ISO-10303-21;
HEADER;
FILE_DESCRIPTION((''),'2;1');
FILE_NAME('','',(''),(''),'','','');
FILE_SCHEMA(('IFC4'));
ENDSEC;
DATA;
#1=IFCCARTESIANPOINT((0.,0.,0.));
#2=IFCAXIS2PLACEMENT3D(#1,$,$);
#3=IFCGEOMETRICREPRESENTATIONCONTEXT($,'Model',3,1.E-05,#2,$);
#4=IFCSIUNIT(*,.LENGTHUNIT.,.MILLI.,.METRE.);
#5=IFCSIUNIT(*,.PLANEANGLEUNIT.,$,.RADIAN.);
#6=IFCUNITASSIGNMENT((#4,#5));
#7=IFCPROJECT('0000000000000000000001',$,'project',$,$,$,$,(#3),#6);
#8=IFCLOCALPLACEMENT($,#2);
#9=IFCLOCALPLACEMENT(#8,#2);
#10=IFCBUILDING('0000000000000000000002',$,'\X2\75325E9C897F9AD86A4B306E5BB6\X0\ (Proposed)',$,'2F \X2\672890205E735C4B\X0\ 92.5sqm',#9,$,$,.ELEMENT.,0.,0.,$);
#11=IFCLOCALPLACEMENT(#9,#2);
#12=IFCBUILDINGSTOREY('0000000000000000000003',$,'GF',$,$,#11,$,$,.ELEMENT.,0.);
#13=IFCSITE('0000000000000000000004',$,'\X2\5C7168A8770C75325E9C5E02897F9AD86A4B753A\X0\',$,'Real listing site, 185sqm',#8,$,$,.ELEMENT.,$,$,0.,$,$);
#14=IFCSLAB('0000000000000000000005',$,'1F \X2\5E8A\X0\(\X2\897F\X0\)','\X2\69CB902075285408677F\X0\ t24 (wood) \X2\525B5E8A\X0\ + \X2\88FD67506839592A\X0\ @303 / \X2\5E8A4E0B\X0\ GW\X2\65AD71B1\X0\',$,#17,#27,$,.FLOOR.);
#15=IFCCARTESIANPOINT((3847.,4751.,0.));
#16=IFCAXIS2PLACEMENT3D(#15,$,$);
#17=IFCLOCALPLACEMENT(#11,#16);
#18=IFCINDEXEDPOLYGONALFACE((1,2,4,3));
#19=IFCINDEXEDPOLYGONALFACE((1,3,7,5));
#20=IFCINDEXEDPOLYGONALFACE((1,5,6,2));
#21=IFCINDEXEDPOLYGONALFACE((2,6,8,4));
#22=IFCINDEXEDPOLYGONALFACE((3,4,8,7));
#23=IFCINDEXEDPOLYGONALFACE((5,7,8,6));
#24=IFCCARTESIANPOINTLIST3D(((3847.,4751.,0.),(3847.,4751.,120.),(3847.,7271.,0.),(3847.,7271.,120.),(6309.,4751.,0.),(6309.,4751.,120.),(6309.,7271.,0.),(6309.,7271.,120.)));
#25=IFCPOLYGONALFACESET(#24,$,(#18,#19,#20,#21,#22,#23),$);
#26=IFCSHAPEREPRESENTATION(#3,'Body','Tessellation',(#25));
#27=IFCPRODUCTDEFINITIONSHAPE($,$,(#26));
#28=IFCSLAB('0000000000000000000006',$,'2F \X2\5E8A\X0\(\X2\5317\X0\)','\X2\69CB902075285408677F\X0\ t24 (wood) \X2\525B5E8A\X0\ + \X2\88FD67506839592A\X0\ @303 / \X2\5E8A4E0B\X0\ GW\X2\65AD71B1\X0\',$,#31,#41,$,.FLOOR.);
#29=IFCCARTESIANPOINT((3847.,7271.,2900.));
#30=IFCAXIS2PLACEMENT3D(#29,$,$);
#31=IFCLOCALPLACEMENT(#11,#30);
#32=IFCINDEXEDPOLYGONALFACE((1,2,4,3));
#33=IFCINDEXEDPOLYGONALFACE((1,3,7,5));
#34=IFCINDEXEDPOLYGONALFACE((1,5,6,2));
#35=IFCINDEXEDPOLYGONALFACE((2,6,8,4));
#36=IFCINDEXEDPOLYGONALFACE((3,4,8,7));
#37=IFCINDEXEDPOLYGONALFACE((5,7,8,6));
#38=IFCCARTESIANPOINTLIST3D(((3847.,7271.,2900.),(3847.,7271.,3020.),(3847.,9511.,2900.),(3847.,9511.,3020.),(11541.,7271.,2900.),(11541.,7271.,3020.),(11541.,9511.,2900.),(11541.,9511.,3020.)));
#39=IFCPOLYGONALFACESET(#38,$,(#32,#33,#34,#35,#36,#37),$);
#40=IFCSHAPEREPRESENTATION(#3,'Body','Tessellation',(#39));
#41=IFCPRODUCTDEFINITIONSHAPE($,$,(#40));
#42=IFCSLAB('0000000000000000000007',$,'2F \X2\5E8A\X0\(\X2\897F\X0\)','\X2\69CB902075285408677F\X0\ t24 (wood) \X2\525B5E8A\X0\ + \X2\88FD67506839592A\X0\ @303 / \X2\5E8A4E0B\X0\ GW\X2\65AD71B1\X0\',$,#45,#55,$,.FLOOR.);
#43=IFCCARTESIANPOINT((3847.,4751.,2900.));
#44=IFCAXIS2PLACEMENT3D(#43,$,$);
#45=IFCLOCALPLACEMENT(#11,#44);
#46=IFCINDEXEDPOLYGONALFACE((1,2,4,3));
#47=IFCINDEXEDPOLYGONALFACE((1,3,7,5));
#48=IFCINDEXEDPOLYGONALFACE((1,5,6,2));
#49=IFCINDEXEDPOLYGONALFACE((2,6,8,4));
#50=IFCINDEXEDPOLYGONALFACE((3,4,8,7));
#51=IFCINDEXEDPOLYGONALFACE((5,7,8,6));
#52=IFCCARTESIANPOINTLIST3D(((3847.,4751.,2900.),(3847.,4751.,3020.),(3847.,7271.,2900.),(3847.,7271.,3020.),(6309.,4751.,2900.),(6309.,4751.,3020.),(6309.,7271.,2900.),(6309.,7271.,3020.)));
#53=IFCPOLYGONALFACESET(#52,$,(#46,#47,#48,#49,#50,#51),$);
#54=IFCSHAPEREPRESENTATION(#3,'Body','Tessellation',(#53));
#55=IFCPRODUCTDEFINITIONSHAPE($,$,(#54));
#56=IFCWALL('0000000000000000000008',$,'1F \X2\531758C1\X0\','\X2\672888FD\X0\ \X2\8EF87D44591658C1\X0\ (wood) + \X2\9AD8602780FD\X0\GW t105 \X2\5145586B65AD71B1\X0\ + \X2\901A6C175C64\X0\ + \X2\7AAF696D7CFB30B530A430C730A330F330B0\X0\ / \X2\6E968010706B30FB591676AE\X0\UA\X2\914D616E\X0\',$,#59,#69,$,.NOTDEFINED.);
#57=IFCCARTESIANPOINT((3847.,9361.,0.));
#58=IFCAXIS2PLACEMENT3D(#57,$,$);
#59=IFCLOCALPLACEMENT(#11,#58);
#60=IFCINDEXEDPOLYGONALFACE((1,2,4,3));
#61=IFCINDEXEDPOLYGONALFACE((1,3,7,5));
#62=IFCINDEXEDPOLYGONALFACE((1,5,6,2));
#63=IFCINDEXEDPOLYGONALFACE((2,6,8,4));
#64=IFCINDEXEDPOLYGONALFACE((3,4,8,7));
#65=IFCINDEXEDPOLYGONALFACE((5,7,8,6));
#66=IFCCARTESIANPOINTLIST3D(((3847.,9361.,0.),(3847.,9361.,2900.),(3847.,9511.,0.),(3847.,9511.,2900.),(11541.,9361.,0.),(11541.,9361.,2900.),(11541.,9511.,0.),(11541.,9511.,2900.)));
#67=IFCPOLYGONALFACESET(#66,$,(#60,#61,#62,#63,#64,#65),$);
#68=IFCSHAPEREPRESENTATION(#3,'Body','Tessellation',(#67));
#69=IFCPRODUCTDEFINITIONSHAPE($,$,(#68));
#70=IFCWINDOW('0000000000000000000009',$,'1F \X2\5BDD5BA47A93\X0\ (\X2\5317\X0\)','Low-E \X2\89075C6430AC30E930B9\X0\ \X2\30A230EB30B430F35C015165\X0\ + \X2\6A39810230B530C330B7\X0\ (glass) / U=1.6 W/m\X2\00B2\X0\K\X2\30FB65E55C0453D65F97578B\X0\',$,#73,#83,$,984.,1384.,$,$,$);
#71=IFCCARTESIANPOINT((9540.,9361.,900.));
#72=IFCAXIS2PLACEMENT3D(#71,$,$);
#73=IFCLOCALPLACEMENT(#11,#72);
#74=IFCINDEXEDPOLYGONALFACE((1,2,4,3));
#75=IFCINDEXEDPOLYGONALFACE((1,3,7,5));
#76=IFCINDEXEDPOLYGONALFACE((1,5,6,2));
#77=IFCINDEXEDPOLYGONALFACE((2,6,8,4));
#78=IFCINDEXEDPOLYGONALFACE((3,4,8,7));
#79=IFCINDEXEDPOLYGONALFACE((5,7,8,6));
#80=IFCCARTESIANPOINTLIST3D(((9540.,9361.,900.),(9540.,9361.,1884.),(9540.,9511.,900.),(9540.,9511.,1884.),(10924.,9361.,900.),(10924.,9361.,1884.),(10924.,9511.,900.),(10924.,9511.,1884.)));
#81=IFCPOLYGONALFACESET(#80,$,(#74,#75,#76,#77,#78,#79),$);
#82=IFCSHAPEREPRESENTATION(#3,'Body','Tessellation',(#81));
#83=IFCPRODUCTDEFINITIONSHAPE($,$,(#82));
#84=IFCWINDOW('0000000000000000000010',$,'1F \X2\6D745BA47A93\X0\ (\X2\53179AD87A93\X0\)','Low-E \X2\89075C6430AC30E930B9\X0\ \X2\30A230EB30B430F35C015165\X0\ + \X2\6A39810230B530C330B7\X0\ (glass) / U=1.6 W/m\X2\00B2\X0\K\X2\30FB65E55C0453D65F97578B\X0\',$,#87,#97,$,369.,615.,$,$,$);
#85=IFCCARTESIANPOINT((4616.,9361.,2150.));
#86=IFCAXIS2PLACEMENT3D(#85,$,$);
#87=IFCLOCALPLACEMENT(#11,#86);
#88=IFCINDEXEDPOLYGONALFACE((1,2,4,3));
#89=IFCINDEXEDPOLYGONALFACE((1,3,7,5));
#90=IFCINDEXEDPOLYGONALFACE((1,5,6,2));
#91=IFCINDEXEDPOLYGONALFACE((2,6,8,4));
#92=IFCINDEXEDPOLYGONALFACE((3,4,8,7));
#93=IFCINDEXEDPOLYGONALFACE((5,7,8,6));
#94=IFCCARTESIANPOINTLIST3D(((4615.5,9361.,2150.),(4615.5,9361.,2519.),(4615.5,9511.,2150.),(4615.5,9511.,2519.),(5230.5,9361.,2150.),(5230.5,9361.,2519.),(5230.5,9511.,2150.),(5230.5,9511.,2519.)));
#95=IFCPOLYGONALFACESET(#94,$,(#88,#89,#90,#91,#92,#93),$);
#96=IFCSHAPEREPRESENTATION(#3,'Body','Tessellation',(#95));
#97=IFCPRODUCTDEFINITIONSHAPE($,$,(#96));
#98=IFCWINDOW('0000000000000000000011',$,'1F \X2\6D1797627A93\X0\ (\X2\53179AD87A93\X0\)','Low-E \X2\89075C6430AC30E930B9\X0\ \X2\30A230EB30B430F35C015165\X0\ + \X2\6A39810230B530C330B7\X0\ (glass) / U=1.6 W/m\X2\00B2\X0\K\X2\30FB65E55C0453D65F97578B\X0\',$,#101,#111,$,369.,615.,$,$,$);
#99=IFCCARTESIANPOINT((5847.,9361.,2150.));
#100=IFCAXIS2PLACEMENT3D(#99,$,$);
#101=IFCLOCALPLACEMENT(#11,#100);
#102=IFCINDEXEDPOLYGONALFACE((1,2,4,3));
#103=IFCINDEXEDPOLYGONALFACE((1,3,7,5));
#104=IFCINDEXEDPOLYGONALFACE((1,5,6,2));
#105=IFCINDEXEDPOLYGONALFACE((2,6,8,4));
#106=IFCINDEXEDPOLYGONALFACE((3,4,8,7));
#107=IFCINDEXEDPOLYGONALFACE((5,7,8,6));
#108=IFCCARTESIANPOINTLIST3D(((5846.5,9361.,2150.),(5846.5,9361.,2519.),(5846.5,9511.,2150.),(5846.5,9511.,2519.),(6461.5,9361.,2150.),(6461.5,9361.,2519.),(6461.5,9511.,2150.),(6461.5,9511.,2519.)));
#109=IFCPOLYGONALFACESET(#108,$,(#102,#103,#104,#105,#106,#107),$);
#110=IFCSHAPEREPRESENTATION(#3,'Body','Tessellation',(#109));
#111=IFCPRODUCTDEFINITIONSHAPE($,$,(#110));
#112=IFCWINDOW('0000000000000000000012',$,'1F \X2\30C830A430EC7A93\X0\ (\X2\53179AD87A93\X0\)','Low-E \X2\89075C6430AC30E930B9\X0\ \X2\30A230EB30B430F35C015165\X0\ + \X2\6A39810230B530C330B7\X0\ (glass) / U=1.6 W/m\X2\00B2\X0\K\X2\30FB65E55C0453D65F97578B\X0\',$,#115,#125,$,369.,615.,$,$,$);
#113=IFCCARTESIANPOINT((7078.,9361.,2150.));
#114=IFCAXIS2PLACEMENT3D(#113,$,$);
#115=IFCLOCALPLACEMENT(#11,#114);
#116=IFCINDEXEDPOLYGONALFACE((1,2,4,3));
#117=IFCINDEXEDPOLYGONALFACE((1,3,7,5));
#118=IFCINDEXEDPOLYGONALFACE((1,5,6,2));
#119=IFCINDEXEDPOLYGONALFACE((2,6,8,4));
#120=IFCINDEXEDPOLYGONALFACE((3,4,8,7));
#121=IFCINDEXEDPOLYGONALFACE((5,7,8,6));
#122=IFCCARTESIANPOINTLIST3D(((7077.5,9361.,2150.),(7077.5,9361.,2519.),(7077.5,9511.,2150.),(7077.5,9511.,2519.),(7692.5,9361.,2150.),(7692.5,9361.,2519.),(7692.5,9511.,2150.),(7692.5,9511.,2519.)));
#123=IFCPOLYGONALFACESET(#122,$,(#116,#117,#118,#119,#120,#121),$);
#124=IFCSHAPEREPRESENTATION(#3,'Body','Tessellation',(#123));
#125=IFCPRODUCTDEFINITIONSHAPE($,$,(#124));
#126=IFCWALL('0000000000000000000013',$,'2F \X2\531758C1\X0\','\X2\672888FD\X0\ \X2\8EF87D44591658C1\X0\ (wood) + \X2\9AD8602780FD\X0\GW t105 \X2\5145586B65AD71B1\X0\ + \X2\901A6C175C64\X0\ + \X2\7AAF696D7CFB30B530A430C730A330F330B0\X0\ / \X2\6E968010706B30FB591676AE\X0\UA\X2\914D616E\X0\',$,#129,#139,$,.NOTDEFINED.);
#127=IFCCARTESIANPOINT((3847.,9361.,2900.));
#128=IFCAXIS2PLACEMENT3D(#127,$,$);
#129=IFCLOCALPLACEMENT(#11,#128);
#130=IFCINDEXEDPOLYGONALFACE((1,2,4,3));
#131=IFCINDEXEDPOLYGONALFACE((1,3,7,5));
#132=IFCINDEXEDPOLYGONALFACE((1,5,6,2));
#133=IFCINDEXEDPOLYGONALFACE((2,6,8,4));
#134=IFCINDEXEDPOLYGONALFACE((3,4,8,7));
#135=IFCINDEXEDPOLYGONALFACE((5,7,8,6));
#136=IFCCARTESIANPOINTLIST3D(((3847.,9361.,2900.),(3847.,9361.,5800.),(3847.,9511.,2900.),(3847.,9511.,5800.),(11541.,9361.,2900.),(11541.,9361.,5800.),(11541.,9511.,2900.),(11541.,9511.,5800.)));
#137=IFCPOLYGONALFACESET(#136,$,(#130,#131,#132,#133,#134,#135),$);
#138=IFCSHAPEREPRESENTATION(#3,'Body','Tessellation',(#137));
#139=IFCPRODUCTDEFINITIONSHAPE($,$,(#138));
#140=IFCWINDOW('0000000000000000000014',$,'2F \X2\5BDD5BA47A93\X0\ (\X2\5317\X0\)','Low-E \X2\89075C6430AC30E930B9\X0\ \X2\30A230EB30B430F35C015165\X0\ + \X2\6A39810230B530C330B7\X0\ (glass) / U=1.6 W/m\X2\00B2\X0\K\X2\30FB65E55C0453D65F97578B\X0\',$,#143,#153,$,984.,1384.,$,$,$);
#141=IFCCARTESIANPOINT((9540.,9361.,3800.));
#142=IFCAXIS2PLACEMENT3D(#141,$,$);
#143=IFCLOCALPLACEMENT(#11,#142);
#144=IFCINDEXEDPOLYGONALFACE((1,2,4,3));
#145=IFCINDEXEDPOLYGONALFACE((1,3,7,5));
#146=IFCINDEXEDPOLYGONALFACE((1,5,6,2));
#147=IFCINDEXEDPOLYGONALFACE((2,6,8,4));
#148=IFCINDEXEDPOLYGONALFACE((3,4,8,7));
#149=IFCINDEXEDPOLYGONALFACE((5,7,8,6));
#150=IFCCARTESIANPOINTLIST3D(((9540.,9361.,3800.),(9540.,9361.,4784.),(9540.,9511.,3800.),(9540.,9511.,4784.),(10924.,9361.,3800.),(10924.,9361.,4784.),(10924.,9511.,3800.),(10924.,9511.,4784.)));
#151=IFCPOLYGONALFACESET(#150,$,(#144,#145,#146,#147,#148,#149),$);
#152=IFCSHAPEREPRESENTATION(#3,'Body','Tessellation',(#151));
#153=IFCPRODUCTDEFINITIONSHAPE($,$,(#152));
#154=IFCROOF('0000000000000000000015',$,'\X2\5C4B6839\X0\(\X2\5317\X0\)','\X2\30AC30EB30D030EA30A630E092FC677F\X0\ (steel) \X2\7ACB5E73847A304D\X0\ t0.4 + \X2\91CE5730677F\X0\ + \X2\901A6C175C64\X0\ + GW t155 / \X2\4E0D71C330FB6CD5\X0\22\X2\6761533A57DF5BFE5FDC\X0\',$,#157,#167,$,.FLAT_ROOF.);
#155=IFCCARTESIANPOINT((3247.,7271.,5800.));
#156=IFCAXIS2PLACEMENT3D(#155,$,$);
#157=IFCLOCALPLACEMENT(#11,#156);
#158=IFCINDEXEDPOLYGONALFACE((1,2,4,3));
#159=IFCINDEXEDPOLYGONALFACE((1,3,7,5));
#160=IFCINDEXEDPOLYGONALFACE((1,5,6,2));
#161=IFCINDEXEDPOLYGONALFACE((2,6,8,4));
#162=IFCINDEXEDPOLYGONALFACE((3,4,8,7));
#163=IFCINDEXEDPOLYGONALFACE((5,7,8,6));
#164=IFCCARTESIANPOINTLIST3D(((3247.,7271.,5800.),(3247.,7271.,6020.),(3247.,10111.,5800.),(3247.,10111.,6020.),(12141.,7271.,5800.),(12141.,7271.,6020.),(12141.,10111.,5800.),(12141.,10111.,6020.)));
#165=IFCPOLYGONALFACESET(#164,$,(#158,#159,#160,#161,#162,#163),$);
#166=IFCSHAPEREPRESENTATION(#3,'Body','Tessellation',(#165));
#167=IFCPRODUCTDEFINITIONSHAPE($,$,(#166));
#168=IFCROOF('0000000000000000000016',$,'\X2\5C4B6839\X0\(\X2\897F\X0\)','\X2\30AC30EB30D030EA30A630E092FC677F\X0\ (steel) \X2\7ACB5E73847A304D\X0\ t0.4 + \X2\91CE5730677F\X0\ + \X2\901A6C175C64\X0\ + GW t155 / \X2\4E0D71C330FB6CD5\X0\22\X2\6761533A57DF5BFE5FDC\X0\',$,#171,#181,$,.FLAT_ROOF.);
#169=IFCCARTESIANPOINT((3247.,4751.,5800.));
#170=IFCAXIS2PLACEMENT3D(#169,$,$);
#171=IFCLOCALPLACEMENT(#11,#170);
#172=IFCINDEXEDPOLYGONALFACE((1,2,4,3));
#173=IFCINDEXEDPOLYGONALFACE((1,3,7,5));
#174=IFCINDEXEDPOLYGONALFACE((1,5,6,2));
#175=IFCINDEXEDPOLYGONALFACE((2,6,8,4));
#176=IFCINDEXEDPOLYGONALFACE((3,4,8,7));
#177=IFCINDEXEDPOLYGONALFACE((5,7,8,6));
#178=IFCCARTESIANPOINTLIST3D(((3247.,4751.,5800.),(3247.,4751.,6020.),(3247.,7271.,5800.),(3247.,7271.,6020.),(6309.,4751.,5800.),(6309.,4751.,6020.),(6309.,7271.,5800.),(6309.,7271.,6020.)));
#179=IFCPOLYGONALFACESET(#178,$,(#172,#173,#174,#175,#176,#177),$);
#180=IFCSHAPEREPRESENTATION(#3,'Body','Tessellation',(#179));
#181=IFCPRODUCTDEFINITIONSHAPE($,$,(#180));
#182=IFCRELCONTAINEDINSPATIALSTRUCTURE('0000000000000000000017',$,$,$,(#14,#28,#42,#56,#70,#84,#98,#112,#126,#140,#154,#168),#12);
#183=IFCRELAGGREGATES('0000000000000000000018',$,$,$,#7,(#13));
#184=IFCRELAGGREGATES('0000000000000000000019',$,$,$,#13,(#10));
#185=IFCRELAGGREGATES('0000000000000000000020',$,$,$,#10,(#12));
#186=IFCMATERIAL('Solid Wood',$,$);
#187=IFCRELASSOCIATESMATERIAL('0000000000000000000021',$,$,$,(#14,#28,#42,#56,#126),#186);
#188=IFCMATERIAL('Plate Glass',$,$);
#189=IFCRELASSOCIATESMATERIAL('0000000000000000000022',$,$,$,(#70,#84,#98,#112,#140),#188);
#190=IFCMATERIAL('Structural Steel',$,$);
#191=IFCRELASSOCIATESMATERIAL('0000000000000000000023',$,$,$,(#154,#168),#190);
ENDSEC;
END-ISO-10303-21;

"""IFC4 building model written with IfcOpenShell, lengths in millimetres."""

from ifc_helpers import new_model, si_unit, frame, frame_2d, origin, place, context, project, spatial, rectangle, extrude, material, element, fill, save


model = new_model("IFC4")

# Units and contexts
model_context = context("Model", 3, precision=1e-05, world=origin())
ifc_project = project(units=[si_unit("LENGTHUNIT", "METRE", prefix="MILLI"), si_unit("PLANEANGLEUNIT", "RADIAN")], contexts=[model_context])

# Site, building, storey
site_placement = place(None, origin())
site = spatial("IfcSite", under=ifc_project, at=site_placement, Name="山梨県甲府市西高橋町", ObjectType="Real listing site, 185sqm", CompositionType="ELEMENT", RefElevation=0.0)
building_placement = place(site_placement, origin())
building = spatial("IfcBuilding", under=site, at=building_placement, Name="甲府西高橋の家 (Proposed)", ObjectType="2F 木造平屋 92.5sqm", CompositionType="ELEMENT", ElevationOfRefHeight=0.0, ElevationOfTerrain=0.0)
storey_placement = place(building_placement, origin())
storey = spatial("IfcBuildingStorey", under=building, at=storey_placement, Name="GF", CompositionType="ELEMENT", Elevation=0.0)

# Slabs
ifc_material_1 = material(Name="Solid Wood")
slab_1_placement = place(storey_placement, frame((3847.0, 4751.0, 0.0)))
element("IfcSlab", 1, at=slab_1_placement, inside=storey, material=ifc_material_1, Name="1F 床(西)", Description="構造用合板 t24 (wood) 剛床 + 製材根太 @303 / 床下 GW断熱", PredefinedType="FLOOR", context=model_context, shape_type="SweptSolid", body=[
    extrude(rectangle(XDim=2462.0, YDim=2520.0, at=frame_2d((1231.0, 1260.0))), frame((3847.0, 4751.0, 0.0)), (0.0, 0.0, 1.0), 120.0),
])
slab_2_placement = place(storey_placement, frame((3847.0, 7271.0, 2900.0)))
element("IfcSlab", 2, at=slab_2_placement, inside=storey, material=ifc_material_1, Name="2F 床(北)", Description="構造用合板 t24 (wood) 剛床 + 製材根太 @303 / 床下 GW断熱", PredefinedType="FLOOR", context=model_context, shape_type="SweptSolid", body=[
    extrude(rectangle(XDim=7694.0, YDim=2240.0, at=frame_2d((3847.0, 1120.0))), frame((3847.0, 7271.0, 2900.0)), (0.0, 0.0, 1.0), 120.0),
])
slab_3_placement = place(storey_placement, frame((3847.0, 4751.0, 2900.0)))
element("IfcSlab", 3, at=slab_3_placement, inside=storey, material=ifc_material_1, Name="2F 床(西)", Description="構造用合板 t24 (wood) 剛床 + 製材根太 @303 / 床下 GW断熱", PredefinedType="FLOOR", context=model_context, shape_type="SweptSolid", body=[
    extrude(rectangle(XDim=2462.0, YDim=2520.0, at=frame_2d((1231.0, 1260.0))), frame((3847.0, 4751.0, 2900.0)), (0.0, 0.0, 1.0), 120.0),
])

# Wall, openings, windows
wall_1_placement = place(storey_placement, frame((3847.0, 9361.0, 0.0)))
wall_1 = element("IfcWall", 4, at=wall_1_placement, inside=storey, material=ifc_material_1, Name="1F 北壁", Description="木製 軸組外壁 (wood) + 高性能GW t105 充填断熱 + 通気層 + 窯業系サイディング / 準耐火・外皮UA配慮", PredefinedType="NOTDEFINED", context=model_context, shape_type="SweptSolid", body=[
    extrude(rectangle(XDim=7694.0, YDim=150.0, at=frame_2d((3847.0, 75.0))), frame((3847.0, 9361.0, 0.0)), (0.0, 0.0, 1.0), 2900.0),
])
opening_1_placement = place(storey_placement, frame((9540.0, 9361.0, 900.0)))
opening_1 = element("IfcOpeningElement", 5, at=opening_1_placement, cuts=wall_1, PredefinedType="NOTDEFINED", context=model_context, shape_type="SweptSolid", body=[
    extrude(rectangle(XDim=1384.0, YDim=150.0, at=frame_2d((692.0, 75.0))), frame((9540.0, 9361.0, 900.0)), (0.0, 0.0, 1.0), 984.0),
])
opening_2_placement = place(storey_placement, frame((4616.0, 9361.0, 2150.0)))
opening_2 = element("IfcOpeningElement", 6, at=opening_2_placement, cuts=wall_1, PredefinedType="NOTDEFINED", context=model_context, shape_type="SweptSolid", body=[
    extrude(rectangle(XDim=615.0, YDim=150.0, at=frame_2d((307.0, 75.0))), frame((4616.0, 9361.0, 2150.0)), (0.0, 0.0, 1.0), 369.0),
])
opening_3_placement = place(storey_placement, frame((5847.0, 9361.0, 2150.0)))
opening_3 = element("IfcOpeningElement", 7, at=opening_3_placement, cuts=wall_1, PredefinedType="NOTDEFINED", context=model_context, shape_type="SweptSolid", body=[
    extrude(rectangle(XDim=615.0, YDim=150.0, at=frame_2d((307.0, 75.0))), frame((5847.0, 9361.0, 2150.0)), (0.0, 0.0, 1.0), 369.0),
])
opening_4_placement = place(storey_placement, frame((7078.0, 9361.0, 2150.0)))
opening_4 = element("IfcOpeningElement", 8, at=opening_4_placement, cuts=wall_1, PredefinedType="NOTDEFINED", context=model_context, shape_type="SweptSolid", body=[
    extrude(rectangle(XDim=615.0, YDim=150.0, at=frame_2d((307.0, 75.0))), frame((7078.0, 9361.0, 2150.0)), (0.0, 0.0, 1.0), 369.0),
])
ifc_material_2 = material(Name="Plate Glass")
window_1_placement = place(storey_placement, frame((9540.0, 9361.0, 900.0)))
window_1 = element("IfcWindow", 9, at=window_1_placement, inside=storey, material=ifc_material_2, Name="1F 寝室窓 (北)", Description="Low-E 複層ガラス アルゴン封入 + 樹脂サッシ (glass) / U=1.6 W/m²K・日射取得型", OverallHeight=984.0, OverallWidth=1384.0, context=model_context, shape_type="SweptSolid", body=[
    extrude(rectangle(XDim=1384.0, YDim=150.0, at=frame_2d((692.0, 75.0))), frame((9540.0, 9361.0, 900.0)), (0.0, 0.0, 1.0), 984.0),
])
fill(opening_1, window_1)
window_2_placement = place(storey_placement, frame((4616.0, 9361.0, 2150.0)))
window_2 = element("IfcWindow", 10, at=window_2_placement, inside=storey, material=ifc_material_2, Name="1F 浴室窓 (北高窓)", Description="Low-E 複層ガラス アルゴン封入 + 樹脂サッシ (glass) / U=1.6 W/m²K・日射取得型", OverallHeight=369.0, OverallWidth=615.0, context=model_context, shape_type="SweptSolid", body=[
    extrude(rectangle(XDim=615.0, YDim=150.0, at=frame_2d((307.0, 75.0))), frame((4616.0, 9361.0, 2150.0)), (0.0, 0.0, 1.0), 369.0),
])
fill(opening_2, window_2)
window_3_placement = place(storey_placement, frame((5847.0, 9361.0, 2150.0)))
window_3 = element("IfcWindow", 11, at=window_3_placement, inside=storey, material=ifc_material_2, Name="1F 洗面窓 (北高窓)", Description="Low-E 複層ガラス アルゴン封入 + 樹脂サッシ (glass) / U=1.6 W/m²K・日射取得型", OverallHeight=369.0, OverallWidth=615.0, context=model_context, shape_type="SweptSolid", body=[
    extrude(rectangle(XDim=615.0, YDim=150.0, at=frame_2d((307.0, 75.0))), frame((5847.0, 9361.0, 2150.0)), (0.0, 0.0, 1.0), 369.0),
])
fill(opening_3, window_3)
window_4_placement = place(storey_placement, frame((7078.0, 9361.0, 2150.0)))
window_4 = element("IfcWindow", 12, at=window_4_placement, inside=storey, material=ifc_material_2, Name="1F トイレ窓 (北高窓)", Description="Low-E 複層ガラス アルゴン封入 + 樹脂サッシ (glass) / U=1.6 W/m²K・日射取得型", OverallHeight=369.0, OverallWidth=615.0, context=model_context, shape_type="SweptSolid", body=[
    extrude(rectangle(XDim=615.0, YDim=150.0, at=frame_2d((307.0, 75.0))), frame((7078.0, 9361.0, 2150.0)), (0.0, 0.0, 1.0), 369.0),
])
fill(opening_4, window_4)

# Wall, opening, window
wall_2_placement = place(storey_placement, frame((3847.0, 9361.0, 2900.0)))
wall_2 = element("IfcWall", 13, at=wall_2_placement, inside=storey, material=ifc_material_1, Name="2F 北壁", Description="木製 軸組外壁 (wood) + 高性能GW t105 充填断熱 + 通気層 + 窯業系サイディング / 準耐火・外皮UA配慮", PredefinedType="NOTDEFINED", context=model_context, shape_type="SweptSolid", body=[
    extrude(rectangle(XDim=7694.0, YDim=150.0, at=frame_2d((3847.0, 75.0))), frame((3847.0, 9361.0, 2900.0)), (0.0, 0.0, 1.0), 2900.0),
])
opening_5_placement = place(storey_placement, frame((9540.0, 9361.0, 3800.0)))
opening_5 = element("IfcOpeningElement", 14, at=opening_5_placement, cuts=wall_2, PredefinedType="NOTDEFINED", context=model_context, shape_type="SweptSolid", body=[
    extrude(rectangle(XDim=1384.0, YDim=150.0, at=frame_2d((692.0, 75.0))), frame((9540.0, 9361.0, 3800.0)), (0.0, 0.0, 1.0), 984.0),
])
window_5_placement = place(storey_placement, frame((9540.0, 9361.0, 3800.0)))
window_5 = element("IfcWindow", 15, at=window_5_placement, inside=storey, material=ifc_material_2, Name="2F 寝室窓 (北)", Description="Low-E 複層ガラス アルゴン封入 + 樹脂サッシ (glass) / U=1.6 W/m²K・日射取得型", OverallHeight=984.0, OverallWidth=1384.0, context=model_context, shape_type="SweptSolid", body=[
    extrude(rectangle(XDim=1384.0, YDim=150.0, at=frame_2d((692.0, 75.0))), frame((9540.0, 9361.0, 3800.0)), (0.0, 0.0, 1.0), 984.0),
])
fill(opening_5, window_5)

# Roofs
ifc_material_3 = material(Name="Structural Steel")
for number, where, name in (
    (16, (3247.0, 7271.0, 5800.0), "屋根(北)"),
):
    element("IfcRoof", number, at=place(storey_placement, frame(where)), inside=storey, material=ifc_material_3, Name=name, Description="ガルバリウム鋼板 (steel) 立平葺き t0.4 + 野地板 + 通気層 + GW t155 / 不燃・法22条区域対応", PredefinedType="FLAT_ROOF", context=model_context, shape_type="SweptSolid", body=[
        extrude(rectangle(XDim=8894.0, YDim=2840.0, at=frame_2d((4447.0, 1420.0))), frame((3247.0, 7271.0, 5800.0)), (0.0, 0.0, 1.0), 220.0),
    ])
roof_placement = place(storey_placement, frame((3247.0, 4751.0, 5800.0)))
element("IfcRoof", 17, at=roof_placement, inside=storey, material=ifc_material_3, Name="屋根(西)", Description="ガルバリウム鋼板 (steel) 立平葺き t0.4 + 野地板 + 通気層 + GW t155 / 不燃・法22条区域対応", PredefinedType="FLAT_ROOF", context=model_context, shape_type="SweptSolid", body=[
    extrude(rectangle(XDim=3062.0, YDim=2520.0, at=frame_2d((1531.0, 1260.0))), frame((3247.0, 4751.0, 5800.0)), (0.0, 0.0, 1.0), 220.0),
])

save(model, "model.ifc")
